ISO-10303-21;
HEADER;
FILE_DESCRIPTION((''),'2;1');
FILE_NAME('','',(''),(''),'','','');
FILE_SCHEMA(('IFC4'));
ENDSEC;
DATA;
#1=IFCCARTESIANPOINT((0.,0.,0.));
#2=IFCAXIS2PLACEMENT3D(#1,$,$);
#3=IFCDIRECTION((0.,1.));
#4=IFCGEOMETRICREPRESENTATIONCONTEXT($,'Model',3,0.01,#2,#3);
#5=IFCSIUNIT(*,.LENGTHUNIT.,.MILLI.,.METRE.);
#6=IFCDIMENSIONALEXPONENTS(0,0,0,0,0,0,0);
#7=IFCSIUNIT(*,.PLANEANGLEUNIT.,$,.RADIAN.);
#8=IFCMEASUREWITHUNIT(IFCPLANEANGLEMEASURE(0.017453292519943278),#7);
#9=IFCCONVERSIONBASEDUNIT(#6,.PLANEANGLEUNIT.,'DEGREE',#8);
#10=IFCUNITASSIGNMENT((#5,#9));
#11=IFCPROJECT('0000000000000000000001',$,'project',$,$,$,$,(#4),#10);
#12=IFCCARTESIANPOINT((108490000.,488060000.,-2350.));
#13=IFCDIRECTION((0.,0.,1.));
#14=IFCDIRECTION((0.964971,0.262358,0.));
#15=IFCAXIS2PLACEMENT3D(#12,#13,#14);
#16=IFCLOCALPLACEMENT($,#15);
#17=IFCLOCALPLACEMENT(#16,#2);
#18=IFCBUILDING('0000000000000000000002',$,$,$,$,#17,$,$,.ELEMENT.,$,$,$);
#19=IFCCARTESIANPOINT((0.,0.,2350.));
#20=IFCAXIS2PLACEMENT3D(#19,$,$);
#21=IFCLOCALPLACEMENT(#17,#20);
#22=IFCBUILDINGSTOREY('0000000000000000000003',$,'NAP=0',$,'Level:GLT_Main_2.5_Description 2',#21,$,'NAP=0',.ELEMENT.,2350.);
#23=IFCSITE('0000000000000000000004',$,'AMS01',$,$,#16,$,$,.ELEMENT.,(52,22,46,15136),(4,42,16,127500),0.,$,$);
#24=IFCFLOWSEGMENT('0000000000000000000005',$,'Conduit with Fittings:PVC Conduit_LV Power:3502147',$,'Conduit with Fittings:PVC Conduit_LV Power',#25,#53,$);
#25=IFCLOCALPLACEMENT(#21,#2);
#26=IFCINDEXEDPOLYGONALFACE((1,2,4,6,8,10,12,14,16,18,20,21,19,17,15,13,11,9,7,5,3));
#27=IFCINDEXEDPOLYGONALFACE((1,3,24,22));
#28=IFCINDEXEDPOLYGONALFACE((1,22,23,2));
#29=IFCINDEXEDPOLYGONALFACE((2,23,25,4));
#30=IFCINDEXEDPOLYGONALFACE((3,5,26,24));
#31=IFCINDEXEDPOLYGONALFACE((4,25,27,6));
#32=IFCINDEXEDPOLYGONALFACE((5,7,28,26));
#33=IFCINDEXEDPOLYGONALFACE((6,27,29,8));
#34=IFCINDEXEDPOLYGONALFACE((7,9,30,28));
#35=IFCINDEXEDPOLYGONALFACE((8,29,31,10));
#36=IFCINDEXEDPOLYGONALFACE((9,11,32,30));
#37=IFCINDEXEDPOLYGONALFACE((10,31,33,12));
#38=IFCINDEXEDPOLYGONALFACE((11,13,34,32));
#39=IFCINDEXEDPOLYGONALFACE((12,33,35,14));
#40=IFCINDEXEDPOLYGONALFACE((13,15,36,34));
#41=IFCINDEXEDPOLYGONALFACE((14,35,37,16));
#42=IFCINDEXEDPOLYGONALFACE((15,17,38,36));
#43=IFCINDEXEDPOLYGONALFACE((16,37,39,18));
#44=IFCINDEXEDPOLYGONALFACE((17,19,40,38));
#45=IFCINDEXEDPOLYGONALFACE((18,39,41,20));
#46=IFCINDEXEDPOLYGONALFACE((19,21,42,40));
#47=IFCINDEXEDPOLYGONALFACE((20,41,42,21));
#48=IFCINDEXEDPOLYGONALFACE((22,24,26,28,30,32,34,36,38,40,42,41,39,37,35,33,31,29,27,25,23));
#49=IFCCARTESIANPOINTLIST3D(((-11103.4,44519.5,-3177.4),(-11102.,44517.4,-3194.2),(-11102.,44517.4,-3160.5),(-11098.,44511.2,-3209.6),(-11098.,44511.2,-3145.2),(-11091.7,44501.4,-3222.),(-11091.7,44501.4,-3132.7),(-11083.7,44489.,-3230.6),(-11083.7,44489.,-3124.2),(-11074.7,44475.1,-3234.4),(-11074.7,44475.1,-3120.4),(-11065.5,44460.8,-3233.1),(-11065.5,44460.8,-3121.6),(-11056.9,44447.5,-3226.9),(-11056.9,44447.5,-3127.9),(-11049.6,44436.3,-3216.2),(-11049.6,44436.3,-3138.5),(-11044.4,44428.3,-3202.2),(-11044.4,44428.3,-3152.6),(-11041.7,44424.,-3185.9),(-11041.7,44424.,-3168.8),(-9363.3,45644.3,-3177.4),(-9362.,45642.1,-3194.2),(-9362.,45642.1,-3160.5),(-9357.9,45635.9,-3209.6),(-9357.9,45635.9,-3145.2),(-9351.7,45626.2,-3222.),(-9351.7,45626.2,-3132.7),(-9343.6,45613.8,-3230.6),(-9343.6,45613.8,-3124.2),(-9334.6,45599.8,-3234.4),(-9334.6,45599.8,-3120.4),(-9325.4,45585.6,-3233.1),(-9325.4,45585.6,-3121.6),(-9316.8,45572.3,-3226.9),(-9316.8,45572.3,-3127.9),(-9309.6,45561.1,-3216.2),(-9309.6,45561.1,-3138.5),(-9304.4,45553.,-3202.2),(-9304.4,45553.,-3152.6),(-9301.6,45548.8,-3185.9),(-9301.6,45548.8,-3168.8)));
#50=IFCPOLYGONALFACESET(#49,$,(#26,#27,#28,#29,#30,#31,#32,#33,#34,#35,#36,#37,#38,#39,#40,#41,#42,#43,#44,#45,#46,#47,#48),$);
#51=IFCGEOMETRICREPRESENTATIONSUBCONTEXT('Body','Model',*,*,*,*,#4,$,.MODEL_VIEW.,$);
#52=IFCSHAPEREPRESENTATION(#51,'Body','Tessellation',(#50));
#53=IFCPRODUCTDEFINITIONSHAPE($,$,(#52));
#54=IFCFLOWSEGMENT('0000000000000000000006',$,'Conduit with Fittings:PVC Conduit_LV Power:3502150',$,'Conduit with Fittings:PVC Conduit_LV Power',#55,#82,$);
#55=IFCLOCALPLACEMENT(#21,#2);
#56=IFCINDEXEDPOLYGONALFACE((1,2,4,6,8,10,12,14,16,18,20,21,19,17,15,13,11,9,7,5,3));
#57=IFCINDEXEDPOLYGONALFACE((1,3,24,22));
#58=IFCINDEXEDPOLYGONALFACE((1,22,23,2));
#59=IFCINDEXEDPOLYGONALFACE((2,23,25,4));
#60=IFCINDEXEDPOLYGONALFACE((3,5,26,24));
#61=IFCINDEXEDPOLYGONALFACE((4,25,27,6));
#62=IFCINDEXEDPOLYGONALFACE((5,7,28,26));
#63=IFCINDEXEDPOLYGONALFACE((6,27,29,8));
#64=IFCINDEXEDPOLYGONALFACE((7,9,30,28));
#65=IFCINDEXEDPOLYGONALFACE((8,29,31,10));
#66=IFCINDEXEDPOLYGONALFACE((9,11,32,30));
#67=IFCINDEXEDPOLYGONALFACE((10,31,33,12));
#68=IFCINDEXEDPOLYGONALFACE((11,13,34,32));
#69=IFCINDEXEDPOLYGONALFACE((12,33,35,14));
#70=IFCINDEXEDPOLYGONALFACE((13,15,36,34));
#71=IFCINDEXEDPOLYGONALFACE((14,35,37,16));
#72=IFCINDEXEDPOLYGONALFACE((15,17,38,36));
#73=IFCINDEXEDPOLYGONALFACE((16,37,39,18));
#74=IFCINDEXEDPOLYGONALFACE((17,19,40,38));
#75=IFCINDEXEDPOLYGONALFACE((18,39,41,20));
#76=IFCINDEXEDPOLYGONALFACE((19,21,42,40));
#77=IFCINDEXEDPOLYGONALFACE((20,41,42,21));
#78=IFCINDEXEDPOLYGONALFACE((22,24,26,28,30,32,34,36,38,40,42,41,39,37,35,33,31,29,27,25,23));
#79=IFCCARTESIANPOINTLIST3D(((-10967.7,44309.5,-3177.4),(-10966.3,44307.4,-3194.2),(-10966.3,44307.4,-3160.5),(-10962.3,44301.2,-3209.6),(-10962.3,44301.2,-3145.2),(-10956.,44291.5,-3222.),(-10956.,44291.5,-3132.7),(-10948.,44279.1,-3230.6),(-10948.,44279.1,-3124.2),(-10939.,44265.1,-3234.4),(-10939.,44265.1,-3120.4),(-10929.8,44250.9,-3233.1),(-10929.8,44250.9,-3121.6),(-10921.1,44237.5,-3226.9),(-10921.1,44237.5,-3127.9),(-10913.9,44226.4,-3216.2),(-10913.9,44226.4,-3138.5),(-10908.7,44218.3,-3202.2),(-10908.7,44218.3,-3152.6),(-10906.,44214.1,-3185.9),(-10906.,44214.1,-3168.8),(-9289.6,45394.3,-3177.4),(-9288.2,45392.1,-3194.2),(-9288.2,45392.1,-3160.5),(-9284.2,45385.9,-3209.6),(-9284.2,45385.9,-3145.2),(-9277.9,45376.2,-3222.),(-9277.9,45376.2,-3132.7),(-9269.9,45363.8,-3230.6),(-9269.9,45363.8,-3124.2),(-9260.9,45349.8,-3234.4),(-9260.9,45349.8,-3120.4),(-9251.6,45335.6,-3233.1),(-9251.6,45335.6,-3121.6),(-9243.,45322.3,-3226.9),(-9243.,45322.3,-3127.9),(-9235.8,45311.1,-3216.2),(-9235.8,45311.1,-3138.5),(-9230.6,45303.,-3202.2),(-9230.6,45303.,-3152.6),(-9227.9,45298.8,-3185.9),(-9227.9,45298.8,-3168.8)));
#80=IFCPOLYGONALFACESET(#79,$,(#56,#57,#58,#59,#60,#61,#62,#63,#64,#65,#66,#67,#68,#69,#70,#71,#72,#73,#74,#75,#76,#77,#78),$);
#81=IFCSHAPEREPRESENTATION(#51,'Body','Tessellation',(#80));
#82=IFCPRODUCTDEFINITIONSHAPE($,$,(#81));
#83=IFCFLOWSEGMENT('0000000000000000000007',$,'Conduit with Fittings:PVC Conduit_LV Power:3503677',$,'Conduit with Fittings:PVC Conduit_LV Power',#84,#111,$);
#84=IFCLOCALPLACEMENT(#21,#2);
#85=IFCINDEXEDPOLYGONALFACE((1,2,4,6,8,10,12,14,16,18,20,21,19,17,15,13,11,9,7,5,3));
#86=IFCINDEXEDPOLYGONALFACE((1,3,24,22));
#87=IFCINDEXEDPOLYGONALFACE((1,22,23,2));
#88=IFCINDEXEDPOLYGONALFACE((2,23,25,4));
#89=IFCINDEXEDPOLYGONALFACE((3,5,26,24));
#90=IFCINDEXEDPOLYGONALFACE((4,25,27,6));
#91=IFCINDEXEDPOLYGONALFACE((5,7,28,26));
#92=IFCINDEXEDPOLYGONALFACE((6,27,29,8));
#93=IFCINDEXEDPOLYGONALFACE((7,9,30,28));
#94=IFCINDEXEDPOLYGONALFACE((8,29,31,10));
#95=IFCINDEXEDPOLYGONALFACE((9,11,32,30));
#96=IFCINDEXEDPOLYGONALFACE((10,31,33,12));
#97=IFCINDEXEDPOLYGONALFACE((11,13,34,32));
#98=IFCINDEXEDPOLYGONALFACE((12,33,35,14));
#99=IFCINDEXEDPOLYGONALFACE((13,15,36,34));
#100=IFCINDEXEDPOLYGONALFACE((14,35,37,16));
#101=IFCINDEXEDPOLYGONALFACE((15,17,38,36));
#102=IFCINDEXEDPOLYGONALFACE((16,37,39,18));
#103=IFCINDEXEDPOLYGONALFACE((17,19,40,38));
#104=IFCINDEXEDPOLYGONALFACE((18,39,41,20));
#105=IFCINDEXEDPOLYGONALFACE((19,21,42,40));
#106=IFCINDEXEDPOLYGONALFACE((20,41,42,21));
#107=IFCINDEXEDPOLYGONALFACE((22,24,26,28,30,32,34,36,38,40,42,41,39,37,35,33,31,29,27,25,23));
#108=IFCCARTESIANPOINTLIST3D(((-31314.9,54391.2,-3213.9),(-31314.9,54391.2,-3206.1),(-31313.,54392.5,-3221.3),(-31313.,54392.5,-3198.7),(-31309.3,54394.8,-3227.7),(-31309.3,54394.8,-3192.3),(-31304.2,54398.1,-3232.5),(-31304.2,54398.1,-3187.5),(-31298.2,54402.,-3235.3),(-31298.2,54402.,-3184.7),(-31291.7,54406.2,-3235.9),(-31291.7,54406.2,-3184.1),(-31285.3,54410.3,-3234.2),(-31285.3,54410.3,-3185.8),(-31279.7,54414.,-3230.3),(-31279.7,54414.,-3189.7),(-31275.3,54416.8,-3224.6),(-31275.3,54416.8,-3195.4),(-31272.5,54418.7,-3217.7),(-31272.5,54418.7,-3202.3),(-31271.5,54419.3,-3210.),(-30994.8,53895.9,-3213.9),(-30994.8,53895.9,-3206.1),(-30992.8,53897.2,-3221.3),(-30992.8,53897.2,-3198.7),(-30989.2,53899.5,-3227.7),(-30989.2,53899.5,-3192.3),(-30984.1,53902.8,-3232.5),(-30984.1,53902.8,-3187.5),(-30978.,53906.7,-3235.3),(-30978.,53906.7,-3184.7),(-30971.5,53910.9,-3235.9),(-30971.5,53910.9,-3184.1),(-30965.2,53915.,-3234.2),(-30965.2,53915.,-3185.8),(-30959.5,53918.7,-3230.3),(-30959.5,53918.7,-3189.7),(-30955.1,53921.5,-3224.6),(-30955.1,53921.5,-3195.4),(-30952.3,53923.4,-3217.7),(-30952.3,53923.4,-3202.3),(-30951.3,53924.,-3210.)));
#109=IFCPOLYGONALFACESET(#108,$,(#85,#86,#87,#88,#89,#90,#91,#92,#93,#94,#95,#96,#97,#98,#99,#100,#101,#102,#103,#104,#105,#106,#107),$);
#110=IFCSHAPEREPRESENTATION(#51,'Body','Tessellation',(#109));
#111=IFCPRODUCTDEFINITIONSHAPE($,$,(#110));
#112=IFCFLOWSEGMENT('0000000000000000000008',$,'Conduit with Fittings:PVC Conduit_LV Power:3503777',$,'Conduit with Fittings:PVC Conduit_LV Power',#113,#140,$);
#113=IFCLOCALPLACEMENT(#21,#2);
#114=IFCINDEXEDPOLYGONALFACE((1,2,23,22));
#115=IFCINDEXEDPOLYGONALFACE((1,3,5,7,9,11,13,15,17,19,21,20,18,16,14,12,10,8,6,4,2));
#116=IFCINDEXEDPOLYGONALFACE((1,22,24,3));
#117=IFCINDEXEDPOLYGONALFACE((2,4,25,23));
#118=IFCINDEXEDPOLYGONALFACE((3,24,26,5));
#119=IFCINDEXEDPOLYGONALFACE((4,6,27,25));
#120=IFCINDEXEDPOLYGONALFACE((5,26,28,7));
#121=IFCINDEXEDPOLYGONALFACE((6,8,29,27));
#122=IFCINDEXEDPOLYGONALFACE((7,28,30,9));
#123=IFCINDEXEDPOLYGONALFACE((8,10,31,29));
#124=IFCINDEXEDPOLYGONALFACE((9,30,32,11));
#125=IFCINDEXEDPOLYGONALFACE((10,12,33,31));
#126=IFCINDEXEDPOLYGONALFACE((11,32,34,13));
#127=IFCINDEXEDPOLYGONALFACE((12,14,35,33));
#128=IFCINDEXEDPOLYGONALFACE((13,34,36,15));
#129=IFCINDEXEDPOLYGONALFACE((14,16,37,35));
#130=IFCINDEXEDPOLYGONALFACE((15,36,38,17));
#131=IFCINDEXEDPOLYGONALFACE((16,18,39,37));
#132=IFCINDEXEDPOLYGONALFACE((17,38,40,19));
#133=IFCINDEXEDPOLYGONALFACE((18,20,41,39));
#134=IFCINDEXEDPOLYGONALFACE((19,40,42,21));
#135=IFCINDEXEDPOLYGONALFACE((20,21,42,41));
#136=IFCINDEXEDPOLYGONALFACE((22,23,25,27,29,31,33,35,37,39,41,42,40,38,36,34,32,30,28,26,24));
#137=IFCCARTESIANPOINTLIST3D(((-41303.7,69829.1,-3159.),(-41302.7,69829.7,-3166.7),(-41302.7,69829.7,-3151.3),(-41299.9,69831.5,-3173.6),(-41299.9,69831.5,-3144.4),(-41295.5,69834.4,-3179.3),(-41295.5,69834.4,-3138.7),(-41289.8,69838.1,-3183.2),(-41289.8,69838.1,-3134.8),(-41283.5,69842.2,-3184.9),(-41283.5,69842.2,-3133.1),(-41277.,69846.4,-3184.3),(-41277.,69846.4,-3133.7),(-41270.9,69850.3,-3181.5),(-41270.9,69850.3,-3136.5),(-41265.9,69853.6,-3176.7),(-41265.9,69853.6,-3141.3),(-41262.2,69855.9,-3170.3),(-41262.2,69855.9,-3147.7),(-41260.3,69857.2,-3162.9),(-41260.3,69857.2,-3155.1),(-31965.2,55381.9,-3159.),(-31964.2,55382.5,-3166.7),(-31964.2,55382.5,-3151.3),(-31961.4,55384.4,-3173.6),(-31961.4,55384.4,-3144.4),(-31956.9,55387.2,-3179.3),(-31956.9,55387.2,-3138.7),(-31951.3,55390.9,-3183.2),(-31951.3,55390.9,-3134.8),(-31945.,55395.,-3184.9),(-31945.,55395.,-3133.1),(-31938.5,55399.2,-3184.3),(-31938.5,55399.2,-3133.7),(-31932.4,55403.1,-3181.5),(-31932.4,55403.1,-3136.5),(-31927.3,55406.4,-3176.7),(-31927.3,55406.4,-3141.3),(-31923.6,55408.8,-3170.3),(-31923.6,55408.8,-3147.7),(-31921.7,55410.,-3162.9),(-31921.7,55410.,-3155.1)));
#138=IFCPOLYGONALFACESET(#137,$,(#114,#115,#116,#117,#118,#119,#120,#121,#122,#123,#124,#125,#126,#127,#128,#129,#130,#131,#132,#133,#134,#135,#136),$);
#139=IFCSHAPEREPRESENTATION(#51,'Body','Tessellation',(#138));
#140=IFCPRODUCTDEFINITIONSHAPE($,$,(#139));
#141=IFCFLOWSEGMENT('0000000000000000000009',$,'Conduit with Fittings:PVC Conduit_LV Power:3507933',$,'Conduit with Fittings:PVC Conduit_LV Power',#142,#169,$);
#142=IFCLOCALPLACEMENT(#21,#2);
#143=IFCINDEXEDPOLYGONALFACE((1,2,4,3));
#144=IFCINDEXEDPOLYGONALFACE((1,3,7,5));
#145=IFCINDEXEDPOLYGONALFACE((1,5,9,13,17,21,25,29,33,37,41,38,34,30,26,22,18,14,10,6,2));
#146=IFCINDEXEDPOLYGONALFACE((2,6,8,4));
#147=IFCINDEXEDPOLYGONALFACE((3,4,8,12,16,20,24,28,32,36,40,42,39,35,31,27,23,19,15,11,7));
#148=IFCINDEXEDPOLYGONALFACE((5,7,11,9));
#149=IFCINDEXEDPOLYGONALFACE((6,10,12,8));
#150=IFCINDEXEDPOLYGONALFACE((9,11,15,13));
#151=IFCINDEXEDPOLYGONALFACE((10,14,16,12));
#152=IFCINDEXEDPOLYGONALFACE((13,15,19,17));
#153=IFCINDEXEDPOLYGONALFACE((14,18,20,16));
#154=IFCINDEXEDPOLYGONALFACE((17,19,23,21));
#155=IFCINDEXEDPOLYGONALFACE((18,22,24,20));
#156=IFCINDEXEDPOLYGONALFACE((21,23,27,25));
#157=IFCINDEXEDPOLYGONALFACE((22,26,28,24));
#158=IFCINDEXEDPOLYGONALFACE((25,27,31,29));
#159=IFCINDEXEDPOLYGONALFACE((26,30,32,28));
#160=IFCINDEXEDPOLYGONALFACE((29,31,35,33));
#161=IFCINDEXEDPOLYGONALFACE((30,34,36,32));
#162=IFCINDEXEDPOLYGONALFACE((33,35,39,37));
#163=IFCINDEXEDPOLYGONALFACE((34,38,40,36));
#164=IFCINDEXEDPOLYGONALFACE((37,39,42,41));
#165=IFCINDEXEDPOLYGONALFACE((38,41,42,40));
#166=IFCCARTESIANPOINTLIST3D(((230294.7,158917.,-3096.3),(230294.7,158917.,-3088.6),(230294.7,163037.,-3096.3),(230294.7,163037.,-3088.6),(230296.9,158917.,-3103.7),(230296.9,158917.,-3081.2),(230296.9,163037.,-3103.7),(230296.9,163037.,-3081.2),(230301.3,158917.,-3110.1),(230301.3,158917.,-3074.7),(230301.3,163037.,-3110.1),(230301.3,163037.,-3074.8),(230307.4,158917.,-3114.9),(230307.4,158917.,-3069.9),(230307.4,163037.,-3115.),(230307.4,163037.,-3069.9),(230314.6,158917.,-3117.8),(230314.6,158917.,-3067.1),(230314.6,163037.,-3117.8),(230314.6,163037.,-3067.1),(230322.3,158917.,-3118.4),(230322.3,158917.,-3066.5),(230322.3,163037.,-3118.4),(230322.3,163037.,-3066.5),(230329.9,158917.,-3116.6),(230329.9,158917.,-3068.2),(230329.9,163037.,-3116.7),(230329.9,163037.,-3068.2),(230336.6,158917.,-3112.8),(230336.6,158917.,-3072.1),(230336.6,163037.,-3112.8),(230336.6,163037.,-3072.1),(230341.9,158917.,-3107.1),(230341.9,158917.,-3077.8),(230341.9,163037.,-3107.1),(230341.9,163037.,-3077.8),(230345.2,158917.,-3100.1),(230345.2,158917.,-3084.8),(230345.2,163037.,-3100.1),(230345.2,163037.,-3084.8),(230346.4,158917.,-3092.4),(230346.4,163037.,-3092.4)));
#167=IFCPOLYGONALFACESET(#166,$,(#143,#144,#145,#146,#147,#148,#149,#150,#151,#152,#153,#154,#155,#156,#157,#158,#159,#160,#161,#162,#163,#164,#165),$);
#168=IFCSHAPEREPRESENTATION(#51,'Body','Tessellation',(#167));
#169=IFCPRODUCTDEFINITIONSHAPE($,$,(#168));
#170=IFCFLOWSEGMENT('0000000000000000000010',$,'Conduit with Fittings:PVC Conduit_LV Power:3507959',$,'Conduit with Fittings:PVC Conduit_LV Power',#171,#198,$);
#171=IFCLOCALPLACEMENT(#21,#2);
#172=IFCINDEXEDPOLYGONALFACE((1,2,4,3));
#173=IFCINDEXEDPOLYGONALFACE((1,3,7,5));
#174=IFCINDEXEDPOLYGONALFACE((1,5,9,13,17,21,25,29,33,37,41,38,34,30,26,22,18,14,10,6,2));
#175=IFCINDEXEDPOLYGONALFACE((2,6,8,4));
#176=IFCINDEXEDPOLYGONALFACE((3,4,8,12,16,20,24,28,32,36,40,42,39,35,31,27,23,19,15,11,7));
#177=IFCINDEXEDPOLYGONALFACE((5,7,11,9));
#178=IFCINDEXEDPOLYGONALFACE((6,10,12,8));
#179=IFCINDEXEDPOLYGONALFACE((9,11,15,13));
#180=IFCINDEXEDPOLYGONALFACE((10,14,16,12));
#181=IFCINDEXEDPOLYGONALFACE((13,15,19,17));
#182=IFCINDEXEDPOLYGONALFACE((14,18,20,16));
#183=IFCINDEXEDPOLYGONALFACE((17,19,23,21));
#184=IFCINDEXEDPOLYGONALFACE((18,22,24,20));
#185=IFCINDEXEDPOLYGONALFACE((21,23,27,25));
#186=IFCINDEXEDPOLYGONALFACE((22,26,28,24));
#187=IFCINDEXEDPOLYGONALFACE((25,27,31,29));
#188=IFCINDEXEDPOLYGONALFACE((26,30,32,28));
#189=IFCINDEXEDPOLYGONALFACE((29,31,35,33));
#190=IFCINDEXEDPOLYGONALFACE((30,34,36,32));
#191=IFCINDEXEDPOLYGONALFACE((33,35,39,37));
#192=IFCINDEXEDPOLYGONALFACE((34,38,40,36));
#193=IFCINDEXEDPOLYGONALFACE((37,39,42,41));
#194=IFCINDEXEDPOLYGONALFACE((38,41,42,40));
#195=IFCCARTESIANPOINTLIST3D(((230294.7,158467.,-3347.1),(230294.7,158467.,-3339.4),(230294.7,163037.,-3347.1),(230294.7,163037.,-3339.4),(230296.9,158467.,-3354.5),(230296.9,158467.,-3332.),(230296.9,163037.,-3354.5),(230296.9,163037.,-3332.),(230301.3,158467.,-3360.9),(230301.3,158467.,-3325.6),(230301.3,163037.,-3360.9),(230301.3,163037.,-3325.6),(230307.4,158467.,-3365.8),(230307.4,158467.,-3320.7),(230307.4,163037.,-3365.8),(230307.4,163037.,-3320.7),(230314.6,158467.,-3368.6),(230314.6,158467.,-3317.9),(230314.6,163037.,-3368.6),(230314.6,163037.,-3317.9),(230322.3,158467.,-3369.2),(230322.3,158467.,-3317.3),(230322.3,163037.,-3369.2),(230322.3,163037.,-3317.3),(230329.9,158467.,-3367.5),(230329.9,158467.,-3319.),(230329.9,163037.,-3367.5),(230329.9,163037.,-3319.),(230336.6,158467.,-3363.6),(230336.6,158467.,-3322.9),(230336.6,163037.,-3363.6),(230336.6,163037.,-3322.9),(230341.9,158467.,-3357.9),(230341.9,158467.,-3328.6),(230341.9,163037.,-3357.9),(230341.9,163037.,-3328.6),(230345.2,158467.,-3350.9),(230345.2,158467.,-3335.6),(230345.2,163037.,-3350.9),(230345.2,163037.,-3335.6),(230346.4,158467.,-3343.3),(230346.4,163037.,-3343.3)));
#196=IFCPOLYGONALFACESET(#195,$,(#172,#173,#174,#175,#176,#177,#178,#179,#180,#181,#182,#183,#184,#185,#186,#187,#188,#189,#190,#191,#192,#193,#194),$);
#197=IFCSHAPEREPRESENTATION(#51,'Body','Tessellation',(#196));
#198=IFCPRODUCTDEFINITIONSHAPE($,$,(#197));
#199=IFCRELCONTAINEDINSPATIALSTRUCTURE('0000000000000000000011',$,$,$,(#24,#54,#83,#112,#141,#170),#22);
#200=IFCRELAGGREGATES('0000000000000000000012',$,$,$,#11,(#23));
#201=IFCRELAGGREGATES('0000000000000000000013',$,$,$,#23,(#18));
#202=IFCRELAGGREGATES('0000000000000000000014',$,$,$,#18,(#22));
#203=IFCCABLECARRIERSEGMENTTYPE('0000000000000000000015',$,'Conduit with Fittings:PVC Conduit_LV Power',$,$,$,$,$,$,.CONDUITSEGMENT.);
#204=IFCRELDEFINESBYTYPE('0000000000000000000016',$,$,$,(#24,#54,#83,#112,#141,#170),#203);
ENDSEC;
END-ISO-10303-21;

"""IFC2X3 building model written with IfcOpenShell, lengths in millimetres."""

from ifc_helpers import new_model, entity, si_unit, converted_unit, direction, frame, frame_2d, origin, origin_2d_with_axis, place, context, subcontext, project, spatial, circle, extrude, type_object, element, save


model = new_model("IFC2X3")

# Units and contexts
model_context = context("Model", 3, precision=0.01, world=origin(), true_north=direction((0.0, 1.0)))
body_context = subcontext(model_context, "Body", "Model", "MODEL_VIEW")
ifc_project = project(units=[si_unit("LENGTHUNIT", "METRE", prefix="MILLI"), converted_unit("PLANEANGLEUNIT", "DEGREE", entity("IfcPlaneAngleMeasure", 0.017453292519943278), si_unit("PLANEANGLEUNIT", "RADIAN"), dimensions=[0, 0, 0, 0, 0, 0, 0])], contexts=[model_context])

# Site, building, storey
site_placement = place(None, frame((108490000.0, 488060000.0, -2350.0), z_axis=(0.0, 0.0, 1.0), x_axis=(0.964971, 0.262358, 0.0)))
site = spatial("IfcSite", under=ifc_project, at=site_placement, Name="AMS01", CompositionType="ELEMENT", RefLatitude=(52, 22, 46, 15136), RefLongitude=(4, 42, 16, 127500), RefElevation=0.0)
building_placement = place(site_placement, origin())
building = spatial("IfcBuilding", under=site, at=building_placement, CompositionType="ELEMENT")
storey_placement = place(building_placement, frame((0.0, 0.0, 2350.0)))
storey = spatial("IfcBuildingStorey", under=building, at=storey_placement, Name="NAP=0", ObjectType="Level:GLT_Main_2.5_Description 2", LongName="NAP=0", CompositionType="ELEMENT", Elevation=2350.0)

# Flow segments
cable_carrier_segment_type = type_object("IfcCableCarrierSegmentType", Name="Conduit with Fittings:PVC Conduit_LV Power", PredefinedType="CONDUITSEGMENT")
flow_segment_1_placement = place(storey_placement, origin())
element("IfcFlowSegment", 1, at=flow_segment_1_placement, inside=storey, type_object=cable_carrier_segment_type, Name="Conduit with Fittings:PVC Conduit_LV Power:3502147", ObjectType="Conduit with Fittings:PVC Conduit_LV Power", context=body_context, shape_type="SweptSolid", body=[
    extrude(circle(Radius=57.2, at=frame_2d((0.0, 0.0), x_axis=(1.0, 0.0))), frame((-11072.4, 44471.5, -3177.4), z_axis=(0.839826, 0.542856, 0.0), x_axis=(-0.542856, 0.839826, 0.0)), (0.0, 0.0, 1.0), 2071.9),
])
flow_segment_2_placement = place(storey_placement, origin())
element("IfcFlowSegment", 2, at=flow_segment_2_placement, inside=storey, type_object=cable_carrier_segment_type, Name="Conduit with Fittings:PVC Conduit_LV Power:3502150", ObjectType="Conduit with Fittings:PVC Conduit_LV Power", context=body_context, shape_type="SweptSolid", body=[
    extrude(circle(Radius=57.2, at=frame_2d((0.0, 0.0), x_axis=(1.0, 0.0))), frame((-10936.7, 44261.5, -3177.4), z_axis=(0.839826, 0.542856, 0.0), x_axis=(-0.542856, 0.839826, 0.0)), (0.0, 0.0, 1.0), 1998.2),
])
flow_segment_3_placement = place(storey_placement, origin())
element("IfcFlowSegment", 3, at=flow_segment_3_placement, inside=storey, type_object=cable_carrier_segment_type, Name="Conduit with Fittings:PVC Conduit_LV Power:3503677", ObjectType="Conduit with Fittings:PVC Conduit_LV Power", context=body_context, shape_type="SweptSolid", body=[
    extrude(circle(Radius=26.0, at=origin_2d_with_axis()), frame((-30973.2, 53909.9, -3210.0), z_axis=(-0.542856, 0.839826, 0.0), x_axis=(0.839826, 0.542856, 0.0)), (0.0, 0.0, 1.0), 589.8),
])
flow_segment_4_placement = place(storey_placement, origin())
element("IfcFlowSegment", 4, at=flow_segment_4_placement, inside=storey, type_object=cable_carrier_segment_type, Name="Conduit with Fittings:PVC Conduit_LV Power:3503777", ObjectType="Conduit with Fittings:PVC Conduit_LV Power", context=body_context, shape_type="SweptSolid", body=[
    extrude(circle(Radius=26.0, at=origin_2d_with_axis()), frame((-41281.9, 69843.2, -3159.0), z_axis=(0.542856, -0.839826, 0.0), x_axis=(-0.839826, -0.542856, 0.0)), (0.0, 0.0, 1.0), 17202.6),
])
flow_segment_5_placement = place(storey_placement, origin())
element("IfcFlowSegment", 5, at=flow_segment_5_placement, inside=storey, type_object=cable_carrier_segment_type, Name="Conduit with Fittings:PVC Conduit_LV Power:3507933", ObjectType="Conduit with Fittings:PVC Conduit_LV Power", context=body_context, shape_type="SweptSolid", body=[
    extrude(circle(Radius=26.0, at=origin_2d_with_axis()), frame((230320.4, 158917.0, -3092.4), z_axis=(0.0, 1.0, -0.000004), x_axis=(1.0, 0.0, 0.0)), (0.0, 0.0, 1.0), 4120.0),
])
flow_segment_6_placement = place(storey_placement, origin())
element("IfcFlowSegment", 6, at=flow_segment_6_placement, inside=storey, type_object=cable_carrier_segment_type, Name="Conduit with Fittings:PVC Conduit_LV Power:3507959", ObjectType="Conduit with Fittings:PVC Conduit_LV Power", context=body_context, shape_type="SweptSolid", body=[
    extrude(circle(Radius=26.0, at=origin_2d_with_axis()), frame((230320.4, 158467.0, -3343.3), z_axis=(0.0, 1.0, 0.0), x_axis=(1.0, 0.0, 0.0)), (0.0, 0.0, 1.0), 4570.0),
])

save(model, "model.ifc")
